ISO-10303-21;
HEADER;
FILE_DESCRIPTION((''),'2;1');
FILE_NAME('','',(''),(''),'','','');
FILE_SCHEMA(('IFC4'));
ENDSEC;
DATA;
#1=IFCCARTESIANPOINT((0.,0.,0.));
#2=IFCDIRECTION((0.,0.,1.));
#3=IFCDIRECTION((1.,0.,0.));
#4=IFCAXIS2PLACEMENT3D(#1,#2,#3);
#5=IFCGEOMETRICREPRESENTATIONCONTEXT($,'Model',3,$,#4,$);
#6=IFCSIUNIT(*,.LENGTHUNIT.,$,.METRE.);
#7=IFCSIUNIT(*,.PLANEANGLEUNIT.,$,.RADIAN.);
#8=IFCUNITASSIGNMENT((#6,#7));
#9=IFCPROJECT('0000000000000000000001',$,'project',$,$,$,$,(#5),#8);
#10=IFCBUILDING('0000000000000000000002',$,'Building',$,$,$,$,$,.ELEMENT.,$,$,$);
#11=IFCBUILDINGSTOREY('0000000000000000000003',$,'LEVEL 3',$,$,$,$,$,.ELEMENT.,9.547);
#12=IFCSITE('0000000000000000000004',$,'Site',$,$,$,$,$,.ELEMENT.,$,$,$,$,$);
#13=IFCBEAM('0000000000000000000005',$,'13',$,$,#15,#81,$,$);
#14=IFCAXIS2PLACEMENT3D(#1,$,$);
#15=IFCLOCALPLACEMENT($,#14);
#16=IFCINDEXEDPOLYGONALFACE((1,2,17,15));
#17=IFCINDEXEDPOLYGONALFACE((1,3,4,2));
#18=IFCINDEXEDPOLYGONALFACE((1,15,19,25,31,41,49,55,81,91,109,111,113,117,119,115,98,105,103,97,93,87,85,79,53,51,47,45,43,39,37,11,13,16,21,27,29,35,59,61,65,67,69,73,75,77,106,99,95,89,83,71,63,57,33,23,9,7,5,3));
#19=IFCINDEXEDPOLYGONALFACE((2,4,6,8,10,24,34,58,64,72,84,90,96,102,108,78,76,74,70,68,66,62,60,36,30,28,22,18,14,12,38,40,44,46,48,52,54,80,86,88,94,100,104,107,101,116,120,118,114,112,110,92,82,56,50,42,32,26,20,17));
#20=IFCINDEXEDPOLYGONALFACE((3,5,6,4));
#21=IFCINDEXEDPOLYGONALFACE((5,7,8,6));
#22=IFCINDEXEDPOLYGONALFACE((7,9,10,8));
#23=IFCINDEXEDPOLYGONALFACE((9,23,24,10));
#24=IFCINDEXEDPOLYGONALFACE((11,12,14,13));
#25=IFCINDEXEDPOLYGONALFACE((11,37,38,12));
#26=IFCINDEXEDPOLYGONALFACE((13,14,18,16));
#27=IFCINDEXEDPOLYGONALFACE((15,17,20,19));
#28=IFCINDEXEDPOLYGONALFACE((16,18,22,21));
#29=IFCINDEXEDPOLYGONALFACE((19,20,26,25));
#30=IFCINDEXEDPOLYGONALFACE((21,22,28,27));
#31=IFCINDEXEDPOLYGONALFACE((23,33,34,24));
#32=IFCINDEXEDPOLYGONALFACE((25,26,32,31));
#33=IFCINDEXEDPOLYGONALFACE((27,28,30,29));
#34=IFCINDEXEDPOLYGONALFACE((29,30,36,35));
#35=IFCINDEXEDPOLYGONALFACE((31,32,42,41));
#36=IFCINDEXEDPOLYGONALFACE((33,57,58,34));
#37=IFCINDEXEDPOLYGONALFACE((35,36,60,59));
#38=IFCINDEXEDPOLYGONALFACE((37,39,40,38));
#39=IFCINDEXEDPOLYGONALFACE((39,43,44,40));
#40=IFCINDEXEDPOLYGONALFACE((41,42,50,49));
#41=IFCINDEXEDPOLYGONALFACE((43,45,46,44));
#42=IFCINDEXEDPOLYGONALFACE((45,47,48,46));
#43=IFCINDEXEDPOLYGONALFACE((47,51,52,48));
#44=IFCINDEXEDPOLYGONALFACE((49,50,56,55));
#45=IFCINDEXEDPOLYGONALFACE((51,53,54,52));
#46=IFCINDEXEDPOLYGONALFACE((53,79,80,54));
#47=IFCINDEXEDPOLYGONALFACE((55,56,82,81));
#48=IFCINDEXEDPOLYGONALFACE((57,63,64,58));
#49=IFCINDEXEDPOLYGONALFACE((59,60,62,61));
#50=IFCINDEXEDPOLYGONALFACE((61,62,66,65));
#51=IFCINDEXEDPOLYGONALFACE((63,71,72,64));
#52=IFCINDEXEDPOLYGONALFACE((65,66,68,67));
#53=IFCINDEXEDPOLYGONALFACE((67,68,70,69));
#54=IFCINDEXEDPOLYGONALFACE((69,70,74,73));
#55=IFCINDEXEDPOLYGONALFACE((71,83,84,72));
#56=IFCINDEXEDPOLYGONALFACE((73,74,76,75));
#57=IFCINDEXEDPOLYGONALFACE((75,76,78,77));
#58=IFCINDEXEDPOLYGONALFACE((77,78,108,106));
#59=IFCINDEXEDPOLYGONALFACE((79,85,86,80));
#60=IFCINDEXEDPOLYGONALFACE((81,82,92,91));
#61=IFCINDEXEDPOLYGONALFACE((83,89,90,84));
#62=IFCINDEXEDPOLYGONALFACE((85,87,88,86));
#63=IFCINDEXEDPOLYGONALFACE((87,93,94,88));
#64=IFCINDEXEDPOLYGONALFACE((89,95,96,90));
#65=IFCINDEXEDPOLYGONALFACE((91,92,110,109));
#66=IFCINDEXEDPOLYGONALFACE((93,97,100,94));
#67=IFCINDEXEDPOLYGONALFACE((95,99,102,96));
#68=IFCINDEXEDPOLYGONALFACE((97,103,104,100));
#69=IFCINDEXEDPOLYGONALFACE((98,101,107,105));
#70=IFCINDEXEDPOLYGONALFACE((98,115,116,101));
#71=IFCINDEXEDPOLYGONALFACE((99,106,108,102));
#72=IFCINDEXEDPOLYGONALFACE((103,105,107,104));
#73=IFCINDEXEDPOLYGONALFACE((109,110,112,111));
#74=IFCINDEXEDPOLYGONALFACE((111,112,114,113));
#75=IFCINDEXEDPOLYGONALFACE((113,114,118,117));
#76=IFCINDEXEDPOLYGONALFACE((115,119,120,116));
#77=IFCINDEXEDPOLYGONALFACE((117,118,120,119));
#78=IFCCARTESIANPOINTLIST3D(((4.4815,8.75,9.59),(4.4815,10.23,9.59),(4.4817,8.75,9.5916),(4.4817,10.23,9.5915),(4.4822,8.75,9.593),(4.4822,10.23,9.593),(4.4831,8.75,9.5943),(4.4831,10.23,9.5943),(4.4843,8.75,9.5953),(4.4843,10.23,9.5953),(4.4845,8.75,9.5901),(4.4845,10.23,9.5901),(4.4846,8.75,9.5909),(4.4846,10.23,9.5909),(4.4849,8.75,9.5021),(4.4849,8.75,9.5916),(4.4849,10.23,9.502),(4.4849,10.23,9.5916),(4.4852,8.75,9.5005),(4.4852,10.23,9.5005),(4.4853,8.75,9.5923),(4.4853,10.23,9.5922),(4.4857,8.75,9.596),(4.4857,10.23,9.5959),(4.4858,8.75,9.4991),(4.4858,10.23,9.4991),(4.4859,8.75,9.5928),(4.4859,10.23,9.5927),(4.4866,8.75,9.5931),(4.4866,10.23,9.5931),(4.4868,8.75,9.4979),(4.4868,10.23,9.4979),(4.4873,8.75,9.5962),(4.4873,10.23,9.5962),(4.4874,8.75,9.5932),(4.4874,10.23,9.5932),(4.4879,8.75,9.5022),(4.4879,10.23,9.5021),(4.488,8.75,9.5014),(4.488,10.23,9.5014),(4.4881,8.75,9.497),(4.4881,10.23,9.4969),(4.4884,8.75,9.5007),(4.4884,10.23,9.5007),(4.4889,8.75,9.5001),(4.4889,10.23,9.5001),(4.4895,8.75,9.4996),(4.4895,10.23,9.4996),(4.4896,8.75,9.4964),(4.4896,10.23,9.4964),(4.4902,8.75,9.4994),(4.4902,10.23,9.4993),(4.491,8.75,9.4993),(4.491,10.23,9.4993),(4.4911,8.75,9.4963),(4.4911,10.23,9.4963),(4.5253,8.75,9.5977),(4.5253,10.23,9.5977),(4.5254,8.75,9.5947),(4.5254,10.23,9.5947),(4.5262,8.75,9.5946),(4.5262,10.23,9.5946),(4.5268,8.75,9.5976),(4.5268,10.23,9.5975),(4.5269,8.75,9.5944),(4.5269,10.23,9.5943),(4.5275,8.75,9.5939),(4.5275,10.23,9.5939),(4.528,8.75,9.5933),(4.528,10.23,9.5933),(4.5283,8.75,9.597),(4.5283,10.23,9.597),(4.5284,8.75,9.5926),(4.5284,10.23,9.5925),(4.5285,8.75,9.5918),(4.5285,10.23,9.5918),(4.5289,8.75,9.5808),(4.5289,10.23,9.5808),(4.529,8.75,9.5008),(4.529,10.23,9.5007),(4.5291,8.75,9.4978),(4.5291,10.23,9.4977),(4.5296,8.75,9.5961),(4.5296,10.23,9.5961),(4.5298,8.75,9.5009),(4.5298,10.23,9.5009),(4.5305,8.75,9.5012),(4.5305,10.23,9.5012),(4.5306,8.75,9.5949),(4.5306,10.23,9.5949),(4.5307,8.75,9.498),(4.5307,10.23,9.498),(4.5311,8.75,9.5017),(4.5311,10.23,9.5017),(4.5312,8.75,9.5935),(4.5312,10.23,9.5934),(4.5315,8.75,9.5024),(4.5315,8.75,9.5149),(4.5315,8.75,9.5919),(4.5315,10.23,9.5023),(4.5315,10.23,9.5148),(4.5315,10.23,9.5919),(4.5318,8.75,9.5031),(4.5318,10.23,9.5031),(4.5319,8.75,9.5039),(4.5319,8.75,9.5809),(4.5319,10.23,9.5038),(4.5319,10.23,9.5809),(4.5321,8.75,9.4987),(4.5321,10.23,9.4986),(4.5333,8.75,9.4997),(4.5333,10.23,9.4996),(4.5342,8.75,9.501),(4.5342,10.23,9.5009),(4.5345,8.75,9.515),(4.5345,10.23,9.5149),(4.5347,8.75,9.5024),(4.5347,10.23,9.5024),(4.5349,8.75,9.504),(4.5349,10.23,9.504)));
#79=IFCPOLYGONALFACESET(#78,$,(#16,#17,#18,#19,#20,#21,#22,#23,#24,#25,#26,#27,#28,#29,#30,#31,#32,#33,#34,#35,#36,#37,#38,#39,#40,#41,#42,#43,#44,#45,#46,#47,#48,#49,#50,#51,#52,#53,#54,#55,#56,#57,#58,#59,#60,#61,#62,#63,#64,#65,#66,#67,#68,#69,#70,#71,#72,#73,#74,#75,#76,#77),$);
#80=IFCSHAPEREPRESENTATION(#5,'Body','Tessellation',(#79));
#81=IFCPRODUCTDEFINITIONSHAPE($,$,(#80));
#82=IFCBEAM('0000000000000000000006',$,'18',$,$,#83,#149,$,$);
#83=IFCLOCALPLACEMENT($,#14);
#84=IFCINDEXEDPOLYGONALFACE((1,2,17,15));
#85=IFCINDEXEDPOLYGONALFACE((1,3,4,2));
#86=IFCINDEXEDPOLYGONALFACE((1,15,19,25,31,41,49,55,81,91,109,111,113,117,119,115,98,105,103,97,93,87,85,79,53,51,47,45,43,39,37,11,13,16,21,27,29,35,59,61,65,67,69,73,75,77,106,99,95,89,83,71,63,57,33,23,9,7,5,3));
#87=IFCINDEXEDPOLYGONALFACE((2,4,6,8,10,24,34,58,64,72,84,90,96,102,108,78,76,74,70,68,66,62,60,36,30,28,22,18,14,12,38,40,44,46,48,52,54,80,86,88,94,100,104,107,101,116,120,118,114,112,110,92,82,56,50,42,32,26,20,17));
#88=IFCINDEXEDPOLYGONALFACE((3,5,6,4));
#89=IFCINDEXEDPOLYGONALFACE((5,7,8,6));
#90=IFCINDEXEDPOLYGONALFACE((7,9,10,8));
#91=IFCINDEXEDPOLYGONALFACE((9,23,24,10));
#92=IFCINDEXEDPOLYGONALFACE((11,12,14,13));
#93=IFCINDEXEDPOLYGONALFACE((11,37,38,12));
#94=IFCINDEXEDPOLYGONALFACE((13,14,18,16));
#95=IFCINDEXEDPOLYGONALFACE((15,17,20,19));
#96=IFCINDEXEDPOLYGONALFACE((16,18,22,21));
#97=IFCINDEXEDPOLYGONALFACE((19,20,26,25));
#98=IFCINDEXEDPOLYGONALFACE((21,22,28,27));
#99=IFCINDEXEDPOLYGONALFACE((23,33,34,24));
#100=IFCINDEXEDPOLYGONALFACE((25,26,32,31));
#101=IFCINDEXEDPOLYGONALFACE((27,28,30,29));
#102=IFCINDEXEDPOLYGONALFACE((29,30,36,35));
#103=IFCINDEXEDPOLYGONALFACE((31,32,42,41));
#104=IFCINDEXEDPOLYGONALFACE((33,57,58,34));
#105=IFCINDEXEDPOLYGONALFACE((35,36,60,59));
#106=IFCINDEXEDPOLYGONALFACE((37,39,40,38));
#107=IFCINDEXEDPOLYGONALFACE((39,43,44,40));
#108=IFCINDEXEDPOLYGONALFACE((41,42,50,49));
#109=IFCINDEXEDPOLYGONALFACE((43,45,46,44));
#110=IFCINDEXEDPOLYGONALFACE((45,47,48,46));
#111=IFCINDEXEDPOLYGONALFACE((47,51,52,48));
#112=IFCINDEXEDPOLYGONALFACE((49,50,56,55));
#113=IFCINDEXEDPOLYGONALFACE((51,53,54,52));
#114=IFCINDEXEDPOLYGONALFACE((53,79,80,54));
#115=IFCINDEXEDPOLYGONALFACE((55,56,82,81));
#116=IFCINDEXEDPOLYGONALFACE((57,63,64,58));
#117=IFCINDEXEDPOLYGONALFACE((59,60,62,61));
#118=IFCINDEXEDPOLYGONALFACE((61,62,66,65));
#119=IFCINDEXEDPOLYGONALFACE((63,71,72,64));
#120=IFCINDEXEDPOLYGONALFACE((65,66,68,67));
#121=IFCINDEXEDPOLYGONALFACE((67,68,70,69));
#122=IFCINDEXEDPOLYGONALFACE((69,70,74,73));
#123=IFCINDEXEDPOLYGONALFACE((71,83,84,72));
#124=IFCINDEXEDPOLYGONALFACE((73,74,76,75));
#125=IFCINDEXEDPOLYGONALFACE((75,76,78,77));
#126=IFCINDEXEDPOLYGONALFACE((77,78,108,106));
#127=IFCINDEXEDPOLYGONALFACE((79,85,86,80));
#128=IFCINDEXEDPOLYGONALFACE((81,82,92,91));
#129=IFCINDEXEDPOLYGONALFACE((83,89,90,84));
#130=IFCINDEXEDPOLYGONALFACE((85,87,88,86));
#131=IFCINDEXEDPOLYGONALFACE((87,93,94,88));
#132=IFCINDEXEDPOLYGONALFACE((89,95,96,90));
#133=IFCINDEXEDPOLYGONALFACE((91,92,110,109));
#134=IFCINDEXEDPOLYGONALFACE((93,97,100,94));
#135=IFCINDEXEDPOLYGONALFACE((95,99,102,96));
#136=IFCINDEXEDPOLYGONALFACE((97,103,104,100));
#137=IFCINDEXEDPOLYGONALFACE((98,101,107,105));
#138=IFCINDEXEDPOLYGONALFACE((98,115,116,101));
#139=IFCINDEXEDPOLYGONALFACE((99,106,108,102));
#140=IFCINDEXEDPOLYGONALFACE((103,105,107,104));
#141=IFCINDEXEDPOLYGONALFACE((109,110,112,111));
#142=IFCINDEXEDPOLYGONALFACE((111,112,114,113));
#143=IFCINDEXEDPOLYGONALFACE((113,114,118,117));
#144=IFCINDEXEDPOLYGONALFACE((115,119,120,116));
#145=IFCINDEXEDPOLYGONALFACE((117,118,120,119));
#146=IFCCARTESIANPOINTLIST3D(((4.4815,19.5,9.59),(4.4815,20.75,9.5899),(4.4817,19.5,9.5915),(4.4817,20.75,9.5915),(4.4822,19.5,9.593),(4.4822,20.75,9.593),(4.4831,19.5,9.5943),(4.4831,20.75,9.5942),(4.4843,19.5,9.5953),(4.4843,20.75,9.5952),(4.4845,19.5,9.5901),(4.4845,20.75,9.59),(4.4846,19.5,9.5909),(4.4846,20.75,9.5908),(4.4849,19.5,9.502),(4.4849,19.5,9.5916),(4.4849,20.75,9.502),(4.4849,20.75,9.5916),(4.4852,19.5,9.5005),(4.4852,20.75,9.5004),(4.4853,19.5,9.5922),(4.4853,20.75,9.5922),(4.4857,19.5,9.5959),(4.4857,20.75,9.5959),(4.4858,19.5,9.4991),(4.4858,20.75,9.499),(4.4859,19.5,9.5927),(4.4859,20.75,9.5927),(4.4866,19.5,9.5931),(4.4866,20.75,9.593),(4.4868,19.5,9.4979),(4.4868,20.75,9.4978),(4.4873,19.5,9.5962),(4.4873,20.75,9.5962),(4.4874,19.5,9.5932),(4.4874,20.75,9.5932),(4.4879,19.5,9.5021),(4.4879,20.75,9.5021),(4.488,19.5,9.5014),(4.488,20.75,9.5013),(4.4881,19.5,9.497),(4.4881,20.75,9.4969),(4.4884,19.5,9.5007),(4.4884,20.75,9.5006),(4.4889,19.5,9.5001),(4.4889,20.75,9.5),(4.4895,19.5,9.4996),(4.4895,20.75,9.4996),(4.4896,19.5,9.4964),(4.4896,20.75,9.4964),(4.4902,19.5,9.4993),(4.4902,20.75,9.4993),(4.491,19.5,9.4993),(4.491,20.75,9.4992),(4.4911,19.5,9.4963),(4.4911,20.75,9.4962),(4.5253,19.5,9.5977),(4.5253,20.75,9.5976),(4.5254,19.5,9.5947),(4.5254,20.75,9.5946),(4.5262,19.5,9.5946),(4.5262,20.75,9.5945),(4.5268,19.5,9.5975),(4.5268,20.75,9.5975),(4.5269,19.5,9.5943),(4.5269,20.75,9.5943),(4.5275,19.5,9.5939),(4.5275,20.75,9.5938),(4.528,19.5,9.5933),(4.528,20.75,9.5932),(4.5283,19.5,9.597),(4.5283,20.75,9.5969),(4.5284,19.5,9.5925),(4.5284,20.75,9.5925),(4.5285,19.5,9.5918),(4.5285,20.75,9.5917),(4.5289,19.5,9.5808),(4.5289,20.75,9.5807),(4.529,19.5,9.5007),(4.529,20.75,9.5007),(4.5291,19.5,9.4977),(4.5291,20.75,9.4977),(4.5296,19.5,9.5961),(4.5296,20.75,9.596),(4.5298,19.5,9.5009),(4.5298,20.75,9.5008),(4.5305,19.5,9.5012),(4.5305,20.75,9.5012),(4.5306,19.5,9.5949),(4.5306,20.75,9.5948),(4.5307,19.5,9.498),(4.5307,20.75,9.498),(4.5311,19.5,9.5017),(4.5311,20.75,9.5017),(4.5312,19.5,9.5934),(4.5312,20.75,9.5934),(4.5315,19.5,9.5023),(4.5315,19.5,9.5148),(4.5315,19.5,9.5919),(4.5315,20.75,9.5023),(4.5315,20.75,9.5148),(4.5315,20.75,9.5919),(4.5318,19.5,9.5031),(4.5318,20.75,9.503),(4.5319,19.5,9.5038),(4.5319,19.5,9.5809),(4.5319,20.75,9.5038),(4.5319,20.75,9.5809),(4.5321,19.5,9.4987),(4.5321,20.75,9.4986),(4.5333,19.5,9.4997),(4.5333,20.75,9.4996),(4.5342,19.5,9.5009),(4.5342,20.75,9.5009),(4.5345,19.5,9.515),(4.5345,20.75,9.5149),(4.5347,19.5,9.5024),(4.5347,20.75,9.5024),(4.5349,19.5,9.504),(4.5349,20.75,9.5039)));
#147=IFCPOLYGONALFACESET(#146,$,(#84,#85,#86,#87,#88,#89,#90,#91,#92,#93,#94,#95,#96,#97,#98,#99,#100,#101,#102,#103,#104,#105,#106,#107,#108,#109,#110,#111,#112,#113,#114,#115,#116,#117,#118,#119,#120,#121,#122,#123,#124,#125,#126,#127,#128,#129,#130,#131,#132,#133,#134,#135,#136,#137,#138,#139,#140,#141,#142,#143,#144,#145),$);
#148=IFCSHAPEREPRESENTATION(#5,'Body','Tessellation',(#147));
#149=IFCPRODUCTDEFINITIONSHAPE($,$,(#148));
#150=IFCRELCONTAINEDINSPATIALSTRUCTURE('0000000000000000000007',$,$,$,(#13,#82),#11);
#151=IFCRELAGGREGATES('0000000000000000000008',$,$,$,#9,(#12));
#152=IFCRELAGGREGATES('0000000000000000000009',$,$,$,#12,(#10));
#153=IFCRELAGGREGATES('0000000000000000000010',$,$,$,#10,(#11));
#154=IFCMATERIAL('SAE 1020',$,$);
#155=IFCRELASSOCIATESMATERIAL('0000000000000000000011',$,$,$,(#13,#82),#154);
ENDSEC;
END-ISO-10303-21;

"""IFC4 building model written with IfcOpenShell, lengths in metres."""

from ifc_helpers import new_model, si_unit, frame, origin_with_axes, origin_2d_with_axis, place, context, project, spatial, c_section, extrude, material, material_profile, profile_set, profile_usage, element, save


model = new_model("IFC4")

# Units and contexts
model_context = context("Model", 3, world=origin_with_axes())
ifc_project = project(units=[si_unit("LENGTHUNIT", "METRE"), si_unit("PLANEANGLEUNIT", "RADIAN")], contexts=[model_context])

# Site, building, storey
site = spatial("IfcSite", under=ifc_project, Name="Site", CompositionType="ELEMENT")
building = spatial("IfcBuilding", under=site, Name="Building", CompositionType="ELEMENT")
storey = spatial("IfcBuildingStorey", under=building, Name="LEVEL 3", CompositionType="ELEMENT", Elevation=9.547)

# Beams
ifc_material = material(Name="SAE 1020")
ifc_material_profile_1 = material_profile(ifc_material, c_section(Depth=0.1, Width=0.05, WallThickness=0.003, Girth=0.017, InternalFilletRadius=0.003, at=origin_2d_with_axis()))
ifc_profile_set_1 = profile_set([ifc_material_profile_1])
ifc_profile_usage_1 = profile_usage(ifc_profile_set_1, cardinal=10)
beam_1_placement = place(None, frame((4.5082, 8.75, 9.547), z_axis=(0.0, 1.0, -0.00003), x_axis=(0.999256, 0.000001, 0.038562)))
element("IfcBeam", 1, at=beam_1_placement, inside=storey, material=ifc_profile_usage_1, Name="13", context=model_context, shape_type="SweptSolid", body=[
    extrude(c_section(Depth=0.1, Width=0.05, WallThickness=0.003, Girth=0.017, InternalFilletRadius=0.003, at=origin_2d_with_axis()), origin_with_axes(), (0.0, 0.0, 1.0), 1.48),
])
ifc_material_profile_2 = material_profile(ifc_material, c_section(Depth=0.1, Width=0.05, WallThickness=0.003, Girth=0.017, InternalFilletRadius=0.003, at=origin_2d_with_axis()))
ifc_profile_set_2 = profile_set([ifc_material_profile_2])
ifc_profile_usage_2 = profile_usage(ifc_profile_set_2, cardinal=10)
beam_2_placement = place(None, frame((4.5082, 19.5, 9.547), z_axis=(0.0, 1.0, -0.00003), x_axis=(0.999256, 0.000001, 0.038562)))
element("IfcBeam", 2, at=beam_2_placement, inside=storey, material=ifc_profile_usage_2, Name="18", context=model_context, shape_type="SweptSolid", body=[
    extrude(c_section(Depth=0.1, Width=0.05, WallThickness=0.003, Girth=0.017, InternalFilletRadius=0.003, at=origin_2d_with_axis()), origin_with_axes(), (0.0, 0.0, 1.0), 1.25),
])

save(model, "model.ifc")
